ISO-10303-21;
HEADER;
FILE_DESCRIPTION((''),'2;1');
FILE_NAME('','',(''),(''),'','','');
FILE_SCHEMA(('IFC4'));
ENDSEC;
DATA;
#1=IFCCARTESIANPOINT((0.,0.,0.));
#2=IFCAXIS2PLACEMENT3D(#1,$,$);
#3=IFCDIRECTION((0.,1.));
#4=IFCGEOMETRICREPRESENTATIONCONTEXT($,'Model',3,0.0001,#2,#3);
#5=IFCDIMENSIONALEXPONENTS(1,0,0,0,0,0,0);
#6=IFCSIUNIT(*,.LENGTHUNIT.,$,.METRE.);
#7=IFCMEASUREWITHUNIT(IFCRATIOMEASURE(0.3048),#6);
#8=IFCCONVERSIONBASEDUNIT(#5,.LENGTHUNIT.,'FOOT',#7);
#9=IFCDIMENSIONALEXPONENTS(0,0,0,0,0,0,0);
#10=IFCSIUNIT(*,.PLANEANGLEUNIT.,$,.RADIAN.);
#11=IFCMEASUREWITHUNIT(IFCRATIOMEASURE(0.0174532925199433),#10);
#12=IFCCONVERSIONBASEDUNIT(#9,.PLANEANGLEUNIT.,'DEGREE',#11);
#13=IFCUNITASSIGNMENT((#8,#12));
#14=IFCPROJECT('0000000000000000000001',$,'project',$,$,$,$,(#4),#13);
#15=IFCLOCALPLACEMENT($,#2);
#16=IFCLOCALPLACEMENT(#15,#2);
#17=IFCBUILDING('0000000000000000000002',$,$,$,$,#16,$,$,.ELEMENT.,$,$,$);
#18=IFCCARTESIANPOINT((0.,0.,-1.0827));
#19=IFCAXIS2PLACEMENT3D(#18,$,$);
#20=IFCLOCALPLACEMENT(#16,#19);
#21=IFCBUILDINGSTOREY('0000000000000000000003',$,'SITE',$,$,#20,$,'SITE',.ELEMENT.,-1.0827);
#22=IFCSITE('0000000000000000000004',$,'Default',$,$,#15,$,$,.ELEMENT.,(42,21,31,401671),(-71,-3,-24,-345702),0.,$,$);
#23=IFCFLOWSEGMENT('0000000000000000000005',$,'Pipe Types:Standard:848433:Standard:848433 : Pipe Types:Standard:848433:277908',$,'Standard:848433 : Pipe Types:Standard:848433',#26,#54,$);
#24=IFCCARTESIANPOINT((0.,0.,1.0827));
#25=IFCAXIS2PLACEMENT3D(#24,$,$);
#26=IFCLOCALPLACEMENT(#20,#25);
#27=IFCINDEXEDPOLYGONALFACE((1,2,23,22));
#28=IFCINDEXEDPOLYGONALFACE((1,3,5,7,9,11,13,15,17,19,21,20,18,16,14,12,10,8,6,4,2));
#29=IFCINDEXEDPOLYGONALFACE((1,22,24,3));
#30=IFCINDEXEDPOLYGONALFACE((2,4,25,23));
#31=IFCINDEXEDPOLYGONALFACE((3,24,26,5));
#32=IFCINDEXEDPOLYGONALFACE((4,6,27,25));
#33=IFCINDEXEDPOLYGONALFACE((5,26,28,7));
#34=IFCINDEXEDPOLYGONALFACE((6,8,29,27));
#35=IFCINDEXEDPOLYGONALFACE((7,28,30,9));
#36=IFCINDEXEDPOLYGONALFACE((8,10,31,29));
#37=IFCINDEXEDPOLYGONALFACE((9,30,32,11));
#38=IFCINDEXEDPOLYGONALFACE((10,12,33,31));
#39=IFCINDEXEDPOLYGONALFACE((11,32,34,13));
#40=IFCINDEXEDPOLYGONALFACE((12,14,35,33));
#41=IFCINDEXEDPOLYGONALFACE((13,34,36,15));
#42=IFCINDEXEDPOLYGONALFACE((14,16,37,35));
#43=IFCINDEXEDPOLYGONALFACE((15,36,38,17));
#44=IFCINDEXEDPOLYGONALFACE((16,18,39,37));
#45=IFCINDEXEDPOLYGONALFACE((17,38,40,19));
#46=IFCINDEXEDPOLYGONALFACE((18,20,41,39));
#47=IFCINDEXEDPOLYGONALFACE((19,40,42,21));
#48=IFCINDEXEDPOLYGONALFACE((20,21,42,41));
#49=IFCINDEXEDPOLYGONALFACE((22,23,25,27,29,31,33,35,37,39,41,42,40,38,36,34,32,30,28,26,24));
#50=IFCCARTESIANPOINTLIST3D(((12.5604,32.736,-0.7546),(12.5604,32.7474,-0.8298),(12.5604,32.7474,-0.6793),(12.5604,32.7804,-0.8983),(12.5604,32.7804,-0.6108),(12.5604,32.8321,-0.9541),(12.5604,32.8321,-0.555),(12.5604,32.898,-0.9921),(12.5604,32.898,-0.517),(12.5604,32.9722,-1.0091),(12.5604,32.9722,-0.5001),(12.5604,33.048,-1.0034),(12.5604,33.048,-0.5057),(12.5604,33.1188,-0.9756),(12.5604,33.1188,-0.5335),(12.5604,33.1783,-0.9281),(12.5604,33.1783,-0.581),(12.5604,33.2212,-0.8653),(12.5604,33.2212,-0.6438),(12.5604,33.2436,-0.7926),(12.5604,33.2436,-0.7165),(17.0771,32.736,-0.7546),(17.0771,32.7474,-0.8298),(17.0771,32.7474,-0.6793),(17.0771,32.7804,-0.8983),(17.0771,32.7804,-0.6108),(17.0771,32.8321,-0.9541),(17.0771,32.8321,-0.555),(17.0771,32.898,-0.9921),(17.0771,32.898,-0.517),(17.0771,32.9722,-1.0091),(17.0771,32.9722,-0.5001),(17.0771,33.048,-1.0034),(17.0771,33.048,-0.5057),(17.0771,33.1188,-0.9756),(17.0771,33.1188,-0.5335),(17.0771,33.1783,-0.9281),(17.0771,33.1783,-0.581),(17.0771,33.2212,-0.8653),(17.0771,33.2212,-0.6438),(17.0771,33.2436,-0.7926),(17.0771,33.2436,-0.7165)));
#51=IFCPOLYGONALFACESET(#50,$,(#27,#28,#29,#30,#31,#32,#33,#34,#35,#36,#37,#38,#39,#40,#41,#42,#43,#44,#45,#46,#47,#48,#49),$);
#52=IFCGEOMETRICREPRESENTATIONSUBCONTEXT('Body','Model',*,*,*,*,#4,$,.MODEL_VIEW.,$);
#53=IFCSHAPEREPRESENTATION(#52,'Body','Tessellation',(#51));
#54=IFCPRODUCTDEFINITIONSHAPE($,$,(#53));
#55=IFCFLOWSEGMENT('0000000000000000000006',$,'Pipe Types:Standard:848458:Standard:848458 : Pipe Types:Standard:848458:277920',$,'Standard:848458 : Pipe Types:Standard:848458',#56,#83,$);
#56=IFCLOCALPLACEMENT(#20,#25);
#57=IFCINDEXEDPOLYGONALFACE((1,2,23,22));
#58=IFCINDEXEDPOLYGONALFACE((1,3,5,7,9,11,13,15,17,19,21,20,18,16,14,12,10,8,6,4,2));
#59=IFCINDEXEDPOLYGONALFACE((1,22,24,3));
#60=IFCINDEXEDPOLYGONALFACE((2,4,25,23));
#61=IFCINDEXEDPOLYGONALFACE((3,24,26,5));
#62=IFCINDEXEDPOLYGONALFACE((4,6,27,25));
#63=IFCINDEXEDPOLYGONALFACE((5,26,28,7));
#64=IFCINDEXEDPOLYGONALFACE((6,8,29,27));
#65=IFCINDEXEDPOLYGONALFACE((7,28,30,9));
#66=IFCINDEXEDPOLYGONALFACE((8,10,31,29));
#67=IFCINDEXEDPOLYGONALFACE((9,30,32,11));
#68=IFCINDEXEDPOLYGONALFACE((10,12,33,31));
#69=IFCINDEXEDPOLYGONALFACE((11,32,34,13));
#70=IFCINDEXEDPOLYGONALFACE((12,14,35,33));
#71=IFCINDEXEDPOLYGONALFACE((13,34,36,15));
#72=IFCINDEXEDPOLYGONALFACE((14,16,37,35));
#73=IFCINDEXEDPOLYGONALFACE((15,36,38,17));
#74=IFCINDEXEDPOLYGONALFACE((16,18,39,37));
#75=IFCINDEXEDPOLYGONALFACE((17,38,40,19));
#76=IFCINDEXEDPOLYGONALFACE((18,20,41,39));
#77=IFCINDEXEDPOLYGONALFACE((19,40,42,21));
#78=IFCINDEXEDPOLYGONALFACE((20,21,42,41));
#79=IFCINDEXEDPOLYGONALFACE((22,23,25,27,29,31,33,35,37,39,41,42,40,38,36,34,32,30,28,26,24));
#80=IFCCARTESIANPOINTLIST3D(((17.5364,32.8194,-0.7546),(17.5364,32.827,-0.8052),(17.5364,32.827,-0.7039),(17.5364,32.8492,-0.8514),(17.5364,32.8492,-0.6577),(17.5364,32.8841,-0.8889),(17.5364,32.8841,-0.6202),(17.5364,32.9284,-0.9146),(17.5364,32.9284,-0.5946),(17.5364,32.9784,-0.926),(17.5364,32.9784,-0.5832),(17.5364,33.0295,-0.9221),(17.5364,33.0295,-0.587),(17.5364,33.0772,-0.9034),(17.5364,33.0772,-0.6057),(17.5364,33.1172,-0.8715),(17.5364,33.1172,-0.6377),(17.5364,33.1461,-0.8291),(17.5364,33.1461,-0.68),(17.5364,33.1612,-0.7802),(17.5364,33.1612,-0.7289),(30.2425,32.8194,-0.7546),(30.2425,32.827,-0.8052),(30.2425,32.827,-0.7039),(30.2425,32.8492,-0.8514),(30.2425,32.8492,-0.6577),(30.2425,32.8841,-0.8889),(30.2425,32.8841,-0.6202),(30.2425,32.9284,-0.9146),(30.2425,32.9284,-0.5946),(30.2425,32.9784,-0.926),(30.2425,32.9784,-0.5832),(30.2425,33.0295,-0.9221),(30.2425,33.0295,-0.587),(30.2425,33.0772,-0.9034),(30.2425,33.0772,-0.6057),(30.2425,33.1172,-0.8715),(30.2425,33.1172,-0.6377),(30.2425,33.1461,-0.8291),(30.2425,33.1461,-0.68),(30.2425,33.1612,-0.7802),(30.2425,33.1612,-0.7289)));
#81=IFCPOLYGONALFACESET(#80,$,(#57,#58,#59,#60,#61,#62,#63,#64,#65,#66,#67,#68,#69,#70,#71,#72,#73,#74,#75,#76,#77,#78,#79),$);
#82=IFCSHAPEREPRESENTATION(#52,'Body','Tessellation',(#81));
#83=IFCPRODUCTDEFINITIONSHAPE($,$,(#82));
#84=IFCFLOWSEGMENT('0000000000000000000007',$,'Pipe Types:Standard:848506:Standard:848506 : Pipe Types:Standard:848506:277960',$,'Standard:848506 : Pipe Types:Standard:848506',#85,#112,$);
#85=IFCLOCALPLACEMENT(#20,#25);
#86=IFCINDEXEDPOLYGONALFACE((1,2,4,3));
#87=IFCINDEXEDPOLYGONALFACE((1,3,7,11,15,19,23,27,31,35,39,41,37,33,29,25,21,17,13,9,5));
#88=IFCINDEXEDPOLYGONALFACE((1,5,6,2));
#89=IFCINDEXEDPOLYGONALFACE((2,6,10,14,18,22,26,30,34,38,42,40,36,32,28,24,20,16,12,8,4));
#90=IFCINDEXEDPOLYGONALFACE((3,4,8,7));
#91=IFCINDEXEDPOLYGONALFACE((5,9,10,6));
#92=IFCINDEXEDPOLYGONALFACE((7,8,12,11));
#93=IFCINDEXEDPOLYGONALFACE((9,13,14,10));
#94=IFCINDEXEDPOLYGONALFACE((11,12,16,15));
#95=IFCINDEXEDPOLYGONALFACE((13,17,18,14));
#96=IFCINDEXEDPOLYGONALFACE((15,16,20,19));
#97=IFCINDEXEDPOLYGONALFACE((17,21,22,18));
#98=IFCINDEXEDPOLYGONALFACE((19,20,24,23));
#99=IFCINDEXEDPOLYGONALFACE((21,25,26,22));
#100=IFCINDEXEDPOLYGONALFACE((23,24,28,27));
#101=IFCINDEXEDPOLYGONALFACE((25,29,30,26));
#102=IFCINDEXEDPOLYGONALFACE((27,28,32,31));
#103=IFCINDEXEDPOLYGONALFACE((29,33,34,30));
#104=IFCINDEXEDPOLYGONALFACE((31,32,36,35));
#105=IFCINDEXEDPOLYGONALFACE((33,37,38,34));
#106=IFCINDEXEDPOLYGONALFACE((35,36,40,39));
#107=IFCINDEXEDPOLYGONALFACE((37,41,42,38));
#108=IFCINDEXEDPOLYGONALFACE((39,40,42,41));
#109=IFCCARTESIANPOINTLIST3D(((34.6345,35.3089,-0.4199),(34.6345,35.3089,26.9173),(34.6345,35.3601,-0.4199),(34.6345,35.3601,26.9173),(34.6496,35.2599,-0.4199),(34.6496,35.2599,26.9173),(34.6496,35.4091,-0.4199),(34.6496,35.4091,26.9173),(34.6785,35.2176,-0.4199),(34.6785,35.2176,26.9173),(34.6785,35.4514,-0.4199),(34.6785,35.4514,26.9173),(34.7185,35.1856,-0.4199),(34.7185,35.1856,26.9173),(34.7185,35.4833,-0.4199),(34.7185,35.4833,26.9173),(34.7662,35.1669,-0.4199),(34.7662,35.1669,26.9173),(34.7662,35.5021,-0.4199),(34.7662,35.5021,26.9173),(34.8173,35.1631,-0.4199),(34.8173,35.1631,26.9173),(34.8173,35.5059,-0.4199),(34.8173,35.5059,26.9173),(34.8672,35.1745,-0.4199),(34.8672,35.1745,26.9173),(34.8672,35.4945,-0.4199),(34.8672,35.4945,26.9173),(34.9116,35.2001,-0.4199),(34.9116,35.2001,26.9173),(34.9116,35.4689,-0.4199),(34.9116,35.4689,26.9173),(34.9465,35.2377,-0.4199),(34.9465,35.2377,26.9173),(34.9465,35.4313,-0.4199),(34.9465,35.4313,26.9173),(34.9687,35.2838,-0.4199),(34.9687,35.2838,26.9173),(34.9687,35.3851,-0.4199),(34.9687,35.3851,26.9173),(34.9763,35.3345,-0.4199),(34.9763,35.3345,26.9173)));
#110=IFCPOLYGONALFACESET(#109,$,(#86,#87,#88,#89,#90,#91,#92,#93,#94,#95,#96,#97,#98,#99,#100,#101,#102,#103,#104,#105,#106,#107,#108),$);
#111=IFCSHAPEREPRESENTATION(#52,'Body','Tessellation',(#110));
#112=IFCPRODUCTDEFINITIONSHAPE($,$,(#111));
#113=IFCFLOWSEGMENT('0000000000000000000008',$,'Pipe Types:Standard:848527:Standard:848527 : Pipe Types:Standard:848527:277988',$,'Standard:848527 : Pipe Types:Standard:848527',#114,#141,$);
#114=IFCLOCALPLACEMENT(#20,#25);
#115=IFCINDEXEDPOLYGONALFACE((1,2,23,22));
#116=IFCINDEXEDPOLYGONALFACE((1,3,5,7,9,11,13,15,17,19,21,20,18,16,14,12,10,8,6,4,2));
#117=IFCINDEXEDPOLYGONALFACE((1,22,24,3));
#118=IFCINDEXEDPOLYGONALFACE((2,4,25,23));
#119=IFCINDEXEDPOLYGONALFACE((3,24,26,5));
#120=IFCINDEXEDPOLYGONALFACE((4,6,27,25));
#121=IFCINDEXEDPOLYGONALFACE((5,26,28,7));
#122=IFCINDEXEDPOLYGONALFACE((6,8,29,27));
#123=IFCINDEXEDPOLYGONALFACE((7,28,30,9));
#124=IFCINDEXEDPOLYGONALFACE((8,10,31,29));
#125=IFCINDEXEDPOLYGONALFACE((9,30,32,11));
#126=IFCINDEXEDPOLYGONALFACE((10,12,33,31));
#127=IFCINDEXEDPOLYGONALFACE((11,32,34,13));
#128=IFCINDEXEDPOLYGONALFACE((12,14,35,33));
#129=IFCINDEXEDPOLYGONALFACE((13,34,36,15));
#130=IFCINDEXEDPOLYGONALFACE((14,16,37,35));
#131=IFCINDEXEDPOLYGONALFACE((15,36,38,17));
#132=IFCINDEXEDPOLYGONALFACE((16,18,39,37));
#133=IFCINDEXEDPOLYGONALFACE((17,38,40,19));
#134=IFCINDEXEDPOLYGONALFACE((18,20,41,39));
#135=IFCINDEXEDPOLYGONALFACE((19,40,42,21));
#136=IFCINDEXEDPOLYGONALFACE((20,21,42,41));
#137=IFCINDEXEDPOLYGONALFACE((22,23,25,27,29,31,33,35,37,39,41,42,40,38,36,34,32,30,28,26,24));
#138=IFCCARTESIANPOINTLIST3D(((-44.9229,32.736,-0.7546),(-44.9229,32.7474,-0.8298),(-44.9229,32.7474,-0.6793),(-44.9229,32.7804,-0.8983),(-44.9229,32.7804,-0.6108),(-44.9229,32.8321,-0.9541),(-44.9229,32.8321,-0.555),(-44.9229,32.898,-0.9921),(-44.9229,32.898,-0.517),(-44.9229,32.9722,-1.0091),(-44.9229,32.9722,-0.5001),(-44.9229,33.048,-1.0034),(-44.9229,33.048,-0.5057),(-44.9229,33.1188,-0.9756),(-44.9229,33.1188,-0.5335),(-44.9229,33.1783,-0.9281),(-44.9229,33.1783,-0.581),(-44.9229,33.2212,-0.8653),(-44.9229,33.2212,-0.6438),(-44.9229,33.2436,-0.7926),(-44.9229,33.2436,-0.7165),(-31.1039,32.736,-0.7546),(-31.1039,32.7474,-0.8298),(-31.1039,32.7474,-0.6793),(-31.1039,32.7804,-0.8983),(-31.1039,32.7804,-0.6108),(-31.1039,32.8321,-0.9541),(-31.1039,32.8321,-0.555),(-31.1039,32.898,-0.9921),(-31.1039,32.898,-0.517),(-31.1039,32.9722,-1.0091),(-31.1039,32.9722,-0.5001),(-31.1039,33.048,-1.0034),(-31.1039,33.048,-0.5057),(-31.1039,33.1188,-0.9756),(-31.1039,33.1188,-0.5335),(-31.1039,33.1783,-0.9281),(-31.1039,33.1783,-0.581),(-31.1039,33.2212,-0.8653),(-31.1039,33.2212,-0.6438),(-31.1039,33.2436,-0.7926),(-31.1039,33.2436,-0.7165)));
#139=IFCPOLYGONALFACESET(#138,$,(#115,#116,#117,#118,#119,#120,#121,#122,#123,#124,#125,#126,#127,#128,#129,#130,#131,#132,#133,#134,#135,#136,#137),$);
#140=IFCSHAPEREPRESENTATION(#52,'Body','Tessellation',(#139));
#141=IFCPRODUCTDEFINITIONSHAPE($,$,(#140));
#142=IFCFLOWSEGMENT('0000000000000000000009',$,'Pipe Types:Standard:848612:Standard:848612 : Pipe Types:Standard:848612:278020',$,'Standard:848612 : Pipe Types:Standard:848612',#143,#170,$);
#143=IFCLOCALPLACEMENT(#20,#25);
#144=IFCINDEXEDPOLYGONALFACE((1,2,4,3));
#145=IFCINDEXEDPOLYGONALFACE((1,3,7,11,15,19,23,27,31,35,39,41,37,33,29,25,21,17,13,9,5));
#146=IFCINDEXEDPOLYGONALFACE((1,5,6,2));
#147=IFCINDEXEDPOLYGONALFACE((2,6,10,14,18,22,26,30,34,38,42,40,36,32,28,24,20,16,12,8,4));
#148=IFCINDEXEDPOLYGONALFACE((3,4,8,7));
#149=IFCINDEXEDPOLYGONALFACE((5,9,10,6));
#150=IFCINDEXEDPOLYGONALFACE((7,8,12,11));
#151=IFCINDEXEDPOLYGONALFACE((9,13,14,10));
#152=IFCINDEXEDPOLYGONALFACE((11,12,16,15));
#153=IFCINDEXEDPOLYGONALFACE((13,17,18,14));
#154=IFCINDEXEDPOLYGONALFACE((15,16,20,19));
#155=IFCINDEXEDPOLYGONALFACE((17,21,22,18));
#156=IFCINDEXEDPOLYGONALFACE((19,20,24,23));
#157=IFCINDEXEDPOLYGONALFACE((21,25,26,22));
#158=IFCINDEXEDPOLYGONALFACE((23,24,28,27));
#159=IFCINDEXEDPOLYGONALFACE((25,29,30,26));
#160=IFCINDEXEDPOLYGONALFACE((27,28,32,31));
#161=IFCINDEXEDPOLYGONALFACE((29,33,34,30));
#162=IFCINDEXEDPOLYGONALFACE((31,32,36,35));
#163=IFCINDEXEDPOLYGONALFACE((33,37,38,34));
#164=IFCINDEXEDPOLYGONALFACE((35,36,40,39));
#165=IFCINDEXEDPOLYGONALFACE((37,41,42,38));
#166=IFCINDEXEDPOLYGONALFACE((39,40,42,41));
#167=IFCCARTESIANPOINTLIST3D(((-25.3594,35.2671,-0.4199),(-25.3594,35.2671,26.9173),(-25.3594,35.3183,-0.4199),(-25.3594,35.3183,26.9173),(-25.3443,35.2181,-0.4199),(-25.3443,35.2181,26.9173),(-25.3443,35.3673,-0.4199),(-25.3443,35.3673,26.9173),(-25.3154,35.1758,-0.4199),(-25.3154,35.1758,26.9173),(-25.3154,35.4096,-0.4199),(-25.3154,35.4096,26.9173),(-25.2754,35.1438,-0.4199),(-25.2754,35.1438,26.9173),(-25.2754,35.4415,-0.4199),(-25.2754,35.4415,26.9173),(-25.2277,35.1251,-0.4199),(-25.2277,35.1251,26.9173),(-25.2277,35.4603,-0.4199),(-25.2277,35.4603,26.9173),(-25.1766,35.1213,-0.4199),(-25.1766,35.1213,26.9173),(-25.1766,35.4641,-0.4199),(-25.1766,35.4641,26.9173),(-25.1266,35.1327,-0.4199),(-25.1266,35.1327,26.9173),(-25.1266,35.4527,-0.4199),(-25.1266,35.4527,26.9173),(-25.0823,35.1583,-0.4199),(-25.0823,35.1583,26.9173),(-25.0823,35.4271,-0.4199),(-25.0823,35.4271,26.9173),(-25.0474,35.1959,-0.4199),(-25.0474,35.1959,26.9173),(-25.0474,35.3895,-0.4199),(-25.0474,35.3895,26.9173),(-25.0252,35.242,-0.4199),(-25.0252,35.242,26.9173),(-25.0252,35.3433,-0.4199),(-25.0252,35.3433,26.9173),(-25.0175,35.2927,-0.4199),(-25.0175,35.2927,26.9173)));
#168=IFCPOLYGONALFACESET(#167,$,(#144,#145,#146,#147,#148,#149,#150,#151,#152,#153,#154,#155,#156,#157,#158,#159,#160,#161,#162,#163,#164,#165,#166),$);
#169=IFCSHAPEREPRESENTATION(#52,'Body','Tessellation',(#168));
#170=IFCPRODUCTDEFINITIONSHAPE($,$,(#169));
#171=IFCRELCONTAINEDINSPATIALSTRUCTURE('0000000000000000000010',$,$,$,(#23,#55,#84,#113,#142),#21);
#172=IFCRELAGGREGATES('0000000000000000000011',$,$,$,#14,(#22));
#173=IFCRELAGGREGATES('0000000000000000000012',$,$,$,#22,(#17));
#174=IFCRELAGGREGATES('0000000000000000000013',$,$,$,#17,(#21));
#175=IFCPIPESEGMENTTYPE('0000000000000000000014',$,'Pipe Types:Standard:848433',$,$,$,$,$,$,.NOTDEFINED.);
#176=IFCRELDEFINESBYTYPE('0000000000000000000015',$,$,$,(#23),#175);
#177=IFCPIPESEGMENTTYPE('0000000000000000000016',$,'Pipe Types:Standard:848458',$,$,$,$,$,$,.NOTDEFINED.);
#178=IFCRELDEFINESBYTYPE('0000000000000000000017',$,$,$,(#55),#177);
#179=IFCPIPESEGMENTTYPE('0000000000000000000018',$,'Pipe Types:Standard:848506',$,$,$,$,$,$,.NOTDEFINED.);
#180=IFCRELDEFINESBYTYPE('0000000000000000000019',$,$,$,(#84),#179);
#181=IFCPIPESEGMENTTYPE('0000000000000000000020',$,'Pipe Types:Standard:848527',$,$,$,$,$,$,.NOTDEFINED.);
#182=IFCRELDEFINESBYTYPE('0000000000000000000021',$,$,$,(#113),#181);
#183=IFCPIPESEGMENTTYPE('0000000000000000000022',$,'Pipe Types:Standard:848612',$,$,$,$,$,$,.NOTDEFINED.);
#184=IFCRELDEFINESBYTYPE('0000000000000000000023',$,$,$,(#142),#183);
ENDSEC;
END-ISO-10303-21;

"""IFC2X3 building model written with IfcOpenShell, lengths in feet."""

from ifc_helpers import new_model, entity, si_unit, converted_unit, direction, frame, frame_2d, origin, origin_2d_with_axis, place, context, subcontext, project, spatial, circle, extrude, source, transform, mapped, type_object, type_shapes, element, save


model = new_model("IFC2X3")

# Units and contexts
model_context = context("Model", 3, precision=0.0001, world=origin(), true_north=direction((0.0, 1.0)))
body_context = subcontext(model_context, "Body", "Model", "MODEL_VIEW")
ifc_project = project(units=[converted_unit("LENGTHUNIT", "FOOT", entity("IfcRatioMeasure", 0.3048), si_unit("LENGTHUNIT", "METRE"), dimensions=[1, 0, 0, 0, 0, 0, 0]), converted_unit("PLANEANGLEUNIT", "DEGREE", entity("IfcRatioMeasure", 0.0174532925199433), si_unit("PLANEANGLEUNIT", "RADIAN"), dimensions=[0, 0, 0, 0, 0, 0, 0])], contexts=[model_context])

# Site, building, storey
site_placement = place(None, origin())
site = spatial("IfcSite", under=ifc_project, at=site_placement, Name="Default", CompositionType="ELEMENT", RefLatitude=(42, 21, 31, 401671), RefLongitude=(-71, -3, -24, -345702), RefElevation=0.0)
building_placement = place(site_placement, origin())
building = spatial("IfcBuilding", under=site, at=building_placement, CompositionType="ELEMENT")
storey_placement = place(building_placement, frame((0.0, 0.0, -1.0827)))
storey = spatial("IfcBuildingStorey", under=building, at=storey_placement, Name="SITE", LongName="SITE", CompositionType="ELEMENT", Elevation=-1.0827)

# Flow segments
pipe_segment_type_1 = type_object("IfcPipeSegmentType", Name="Pipe Types:Standard:848433", PredefinedType="NOTDEFINED")
shared_shape_1 = source(origin(), body_context, "Body", "SweptSolid", [
    extrude(circle(Radius=0.2552, at=frame_2d((0.0, 0.0), x_axis=(1.0, 0.0))), frame((12.5604, 32.9912, -0.7546), z_axis=(1.0, 0.0, 0.0), x_axis=(0.0, -1.0, 0.0)), (0.0, 0.0, 1.0), 4.5167),
])
type_shapes(pipe_segment_type_1, [shared_shape_1])
flow_segment_1_placement = place(storey_placement, frame((0.0, 0.0, 1.0827)))
element("IfcFlowSegment", 1, at=flow_segment_1_placement, inside=storey, type_object=pipe_segment_type_1, Name="Pipe Types:Standard:848433:Standard:848433 : Pipe Types:Standard:848433:277908", ObjectType="Standard:848433 : Pipe Types:Standard:848433", context=body_context, shape_type="MappedRepresentation", body=[
    mapped(shared_shape_1, transform((0.0, 0.0, 0.0), scale=1.0)),
])
pipe_segment_type_2 = type_object("IfcPipeSegmentType", Name="Pipe Types:Standard:848458", PredefinedType="NOTDEFINED")
shared_shape_2 = source(origin(), body_context, "Body", "SweptSolid", [
    extrude(circle(Radius=0.1719, at=frame_2d((0.0, 0.0), x_axis=(1.0, 0.0))), frame((17.5364, 32.9912, -0.7546), z_axis=(1.0, 0.0, 0.0), x_axis=(0.0, -1.0, 0.0)), (0.0, 0.0, 1.0), 12.706),
])
type_shapes(pipe_segment_type_2, [shared_shape_2])
flow_segment_2_placement = place(storey_placement, frame((0.0, 0.0, 1.0827)))
element("IfcFlowSegment", 2, at=flow_segment_2_placement, inside=storey, type_object=pipe_segment_type_2, Name="Pipe Types:Standard:848458:Standard:848458 : Pipe Types:Standard:848458:277920", ObjectType="Standard:848458 : Pipe Types:Standard:848458", context=body_context, shape_type="MappedRepresentation", body=[
    mapped(shared_shape_2, transform((0.0, 0.0, 0.0), scale=1.0)),
])
pipe_segment_type_3 = type_object("IfcPipeSegmentType", Name="Pipe Types:Standard:848506", PredefinedType="NOTDEFINED")
shared_shape_3 = source(origin(), body_context, "Body", "SweptSolid", [
    extrude(circle(Radius=0.1719, at=origin_2d_with_axis()), frame((34.8045, 35.3345, -0.4199)), (0.0, 0.0, 1.0), 27.3372),
])
type_shapes(pipe_segment_type_3, [shared_shape_3])
flow_segment_3_placement = place(storey_placement, frame((0.0, 0.0, 1.0827)))
element("IfcFlowSegment", 3, at=flow_segment_3_placement, inside=storey, type_object=pipe_segment_type_3, Name="Pipe Types:Standard:848506:Standard:848506 : Pipe Types:Standard:848506:277960", ObjectType="Standard:848506 : Pipe Types:Standard:848506", context=body_context, shape_type="MappedRepresentation", body=[
    mapped(shared_shape_3, transform((0.0, 0.0, 0.0), scale=1.0)),
])
pipe_segment_type_4 = type_object("IfcPipeSegmentType", Name="Pipe Types:Standard:848527", PredefinedType="NOTDEFINED")
shared_shape_4 = source(origin(), body_context, "Body", "SweptSolid", [
    extrude(circle(Radius=0.2552, at=frame_2d((0.0, 0.0), x_axis=(1.0, 0.0))), frame((-44.9229, 32.9912, -0.7546), z_axis=(1.0, 0.0, 0.0), x_axis=(0.0, -1.0, 0.0)), (0.0, 0.0, 1.0), 13.8189),
])
type_shapes(pipe_segment_type_4, [shared_shape_4])
flow_segment_4_placement = place(storey_placement, frame((0.0, 0.0, 1.0827)))
element("IfcFlowSegment", 4, at=flow_segment_4_placement, inside=storey, type_object=pipe_segment_type_4, Name="Pipe Types:Standard:848527:Standard:848527 : Pipe Types:Standard:848527:277988", ObjectType="Standard:848527 : Pipe Types:Standard:848527", context=body_context, shape_type="MappedRepresentation", body=[
    mapped(shared_shape_4, transform((0.0, 0.0, 0.0), scale=1.0)),
])
pipe_segment_type_5 = type_object("IfcPipeSegmentType", Name="Pipe Types:Standard:848612", PredefinedType="NOTDEFINED")
shared_shape_5 = source(origin(), body_context, "Body", "SweptSolid", [
    extrude(circle(Radius=0.1719, at=origin_2d_with_axis()), frame((-25.1894, 35.2927, -0.4199)), (0.0, 0.0, 1.0), 27.3372),
])
type_shapes(pipe_segment_type_5, [shared_shape_5])
flow_segment_5_placement = place(storey_placement, frame((0.0, 0.0, 1.0827)))
element("IfcFlowSegment", 5, at=flow_segment_5_placement, inside=storey, type_object=pipe_segment_type_5, Name="Pipe Types:Standard:848612:Standard:848612 : Pipe Types:Standard:848612:278020", ObjectType="Standard:848612 : Pipe Types:Standard:848612", context=body_context, shape_type="MappedRepresentation", body=[
    mapped(shared_shape_5, transform((0.0, 0.0, 0.0), scale=1.0)),
])

save(model, "model.ifc")
